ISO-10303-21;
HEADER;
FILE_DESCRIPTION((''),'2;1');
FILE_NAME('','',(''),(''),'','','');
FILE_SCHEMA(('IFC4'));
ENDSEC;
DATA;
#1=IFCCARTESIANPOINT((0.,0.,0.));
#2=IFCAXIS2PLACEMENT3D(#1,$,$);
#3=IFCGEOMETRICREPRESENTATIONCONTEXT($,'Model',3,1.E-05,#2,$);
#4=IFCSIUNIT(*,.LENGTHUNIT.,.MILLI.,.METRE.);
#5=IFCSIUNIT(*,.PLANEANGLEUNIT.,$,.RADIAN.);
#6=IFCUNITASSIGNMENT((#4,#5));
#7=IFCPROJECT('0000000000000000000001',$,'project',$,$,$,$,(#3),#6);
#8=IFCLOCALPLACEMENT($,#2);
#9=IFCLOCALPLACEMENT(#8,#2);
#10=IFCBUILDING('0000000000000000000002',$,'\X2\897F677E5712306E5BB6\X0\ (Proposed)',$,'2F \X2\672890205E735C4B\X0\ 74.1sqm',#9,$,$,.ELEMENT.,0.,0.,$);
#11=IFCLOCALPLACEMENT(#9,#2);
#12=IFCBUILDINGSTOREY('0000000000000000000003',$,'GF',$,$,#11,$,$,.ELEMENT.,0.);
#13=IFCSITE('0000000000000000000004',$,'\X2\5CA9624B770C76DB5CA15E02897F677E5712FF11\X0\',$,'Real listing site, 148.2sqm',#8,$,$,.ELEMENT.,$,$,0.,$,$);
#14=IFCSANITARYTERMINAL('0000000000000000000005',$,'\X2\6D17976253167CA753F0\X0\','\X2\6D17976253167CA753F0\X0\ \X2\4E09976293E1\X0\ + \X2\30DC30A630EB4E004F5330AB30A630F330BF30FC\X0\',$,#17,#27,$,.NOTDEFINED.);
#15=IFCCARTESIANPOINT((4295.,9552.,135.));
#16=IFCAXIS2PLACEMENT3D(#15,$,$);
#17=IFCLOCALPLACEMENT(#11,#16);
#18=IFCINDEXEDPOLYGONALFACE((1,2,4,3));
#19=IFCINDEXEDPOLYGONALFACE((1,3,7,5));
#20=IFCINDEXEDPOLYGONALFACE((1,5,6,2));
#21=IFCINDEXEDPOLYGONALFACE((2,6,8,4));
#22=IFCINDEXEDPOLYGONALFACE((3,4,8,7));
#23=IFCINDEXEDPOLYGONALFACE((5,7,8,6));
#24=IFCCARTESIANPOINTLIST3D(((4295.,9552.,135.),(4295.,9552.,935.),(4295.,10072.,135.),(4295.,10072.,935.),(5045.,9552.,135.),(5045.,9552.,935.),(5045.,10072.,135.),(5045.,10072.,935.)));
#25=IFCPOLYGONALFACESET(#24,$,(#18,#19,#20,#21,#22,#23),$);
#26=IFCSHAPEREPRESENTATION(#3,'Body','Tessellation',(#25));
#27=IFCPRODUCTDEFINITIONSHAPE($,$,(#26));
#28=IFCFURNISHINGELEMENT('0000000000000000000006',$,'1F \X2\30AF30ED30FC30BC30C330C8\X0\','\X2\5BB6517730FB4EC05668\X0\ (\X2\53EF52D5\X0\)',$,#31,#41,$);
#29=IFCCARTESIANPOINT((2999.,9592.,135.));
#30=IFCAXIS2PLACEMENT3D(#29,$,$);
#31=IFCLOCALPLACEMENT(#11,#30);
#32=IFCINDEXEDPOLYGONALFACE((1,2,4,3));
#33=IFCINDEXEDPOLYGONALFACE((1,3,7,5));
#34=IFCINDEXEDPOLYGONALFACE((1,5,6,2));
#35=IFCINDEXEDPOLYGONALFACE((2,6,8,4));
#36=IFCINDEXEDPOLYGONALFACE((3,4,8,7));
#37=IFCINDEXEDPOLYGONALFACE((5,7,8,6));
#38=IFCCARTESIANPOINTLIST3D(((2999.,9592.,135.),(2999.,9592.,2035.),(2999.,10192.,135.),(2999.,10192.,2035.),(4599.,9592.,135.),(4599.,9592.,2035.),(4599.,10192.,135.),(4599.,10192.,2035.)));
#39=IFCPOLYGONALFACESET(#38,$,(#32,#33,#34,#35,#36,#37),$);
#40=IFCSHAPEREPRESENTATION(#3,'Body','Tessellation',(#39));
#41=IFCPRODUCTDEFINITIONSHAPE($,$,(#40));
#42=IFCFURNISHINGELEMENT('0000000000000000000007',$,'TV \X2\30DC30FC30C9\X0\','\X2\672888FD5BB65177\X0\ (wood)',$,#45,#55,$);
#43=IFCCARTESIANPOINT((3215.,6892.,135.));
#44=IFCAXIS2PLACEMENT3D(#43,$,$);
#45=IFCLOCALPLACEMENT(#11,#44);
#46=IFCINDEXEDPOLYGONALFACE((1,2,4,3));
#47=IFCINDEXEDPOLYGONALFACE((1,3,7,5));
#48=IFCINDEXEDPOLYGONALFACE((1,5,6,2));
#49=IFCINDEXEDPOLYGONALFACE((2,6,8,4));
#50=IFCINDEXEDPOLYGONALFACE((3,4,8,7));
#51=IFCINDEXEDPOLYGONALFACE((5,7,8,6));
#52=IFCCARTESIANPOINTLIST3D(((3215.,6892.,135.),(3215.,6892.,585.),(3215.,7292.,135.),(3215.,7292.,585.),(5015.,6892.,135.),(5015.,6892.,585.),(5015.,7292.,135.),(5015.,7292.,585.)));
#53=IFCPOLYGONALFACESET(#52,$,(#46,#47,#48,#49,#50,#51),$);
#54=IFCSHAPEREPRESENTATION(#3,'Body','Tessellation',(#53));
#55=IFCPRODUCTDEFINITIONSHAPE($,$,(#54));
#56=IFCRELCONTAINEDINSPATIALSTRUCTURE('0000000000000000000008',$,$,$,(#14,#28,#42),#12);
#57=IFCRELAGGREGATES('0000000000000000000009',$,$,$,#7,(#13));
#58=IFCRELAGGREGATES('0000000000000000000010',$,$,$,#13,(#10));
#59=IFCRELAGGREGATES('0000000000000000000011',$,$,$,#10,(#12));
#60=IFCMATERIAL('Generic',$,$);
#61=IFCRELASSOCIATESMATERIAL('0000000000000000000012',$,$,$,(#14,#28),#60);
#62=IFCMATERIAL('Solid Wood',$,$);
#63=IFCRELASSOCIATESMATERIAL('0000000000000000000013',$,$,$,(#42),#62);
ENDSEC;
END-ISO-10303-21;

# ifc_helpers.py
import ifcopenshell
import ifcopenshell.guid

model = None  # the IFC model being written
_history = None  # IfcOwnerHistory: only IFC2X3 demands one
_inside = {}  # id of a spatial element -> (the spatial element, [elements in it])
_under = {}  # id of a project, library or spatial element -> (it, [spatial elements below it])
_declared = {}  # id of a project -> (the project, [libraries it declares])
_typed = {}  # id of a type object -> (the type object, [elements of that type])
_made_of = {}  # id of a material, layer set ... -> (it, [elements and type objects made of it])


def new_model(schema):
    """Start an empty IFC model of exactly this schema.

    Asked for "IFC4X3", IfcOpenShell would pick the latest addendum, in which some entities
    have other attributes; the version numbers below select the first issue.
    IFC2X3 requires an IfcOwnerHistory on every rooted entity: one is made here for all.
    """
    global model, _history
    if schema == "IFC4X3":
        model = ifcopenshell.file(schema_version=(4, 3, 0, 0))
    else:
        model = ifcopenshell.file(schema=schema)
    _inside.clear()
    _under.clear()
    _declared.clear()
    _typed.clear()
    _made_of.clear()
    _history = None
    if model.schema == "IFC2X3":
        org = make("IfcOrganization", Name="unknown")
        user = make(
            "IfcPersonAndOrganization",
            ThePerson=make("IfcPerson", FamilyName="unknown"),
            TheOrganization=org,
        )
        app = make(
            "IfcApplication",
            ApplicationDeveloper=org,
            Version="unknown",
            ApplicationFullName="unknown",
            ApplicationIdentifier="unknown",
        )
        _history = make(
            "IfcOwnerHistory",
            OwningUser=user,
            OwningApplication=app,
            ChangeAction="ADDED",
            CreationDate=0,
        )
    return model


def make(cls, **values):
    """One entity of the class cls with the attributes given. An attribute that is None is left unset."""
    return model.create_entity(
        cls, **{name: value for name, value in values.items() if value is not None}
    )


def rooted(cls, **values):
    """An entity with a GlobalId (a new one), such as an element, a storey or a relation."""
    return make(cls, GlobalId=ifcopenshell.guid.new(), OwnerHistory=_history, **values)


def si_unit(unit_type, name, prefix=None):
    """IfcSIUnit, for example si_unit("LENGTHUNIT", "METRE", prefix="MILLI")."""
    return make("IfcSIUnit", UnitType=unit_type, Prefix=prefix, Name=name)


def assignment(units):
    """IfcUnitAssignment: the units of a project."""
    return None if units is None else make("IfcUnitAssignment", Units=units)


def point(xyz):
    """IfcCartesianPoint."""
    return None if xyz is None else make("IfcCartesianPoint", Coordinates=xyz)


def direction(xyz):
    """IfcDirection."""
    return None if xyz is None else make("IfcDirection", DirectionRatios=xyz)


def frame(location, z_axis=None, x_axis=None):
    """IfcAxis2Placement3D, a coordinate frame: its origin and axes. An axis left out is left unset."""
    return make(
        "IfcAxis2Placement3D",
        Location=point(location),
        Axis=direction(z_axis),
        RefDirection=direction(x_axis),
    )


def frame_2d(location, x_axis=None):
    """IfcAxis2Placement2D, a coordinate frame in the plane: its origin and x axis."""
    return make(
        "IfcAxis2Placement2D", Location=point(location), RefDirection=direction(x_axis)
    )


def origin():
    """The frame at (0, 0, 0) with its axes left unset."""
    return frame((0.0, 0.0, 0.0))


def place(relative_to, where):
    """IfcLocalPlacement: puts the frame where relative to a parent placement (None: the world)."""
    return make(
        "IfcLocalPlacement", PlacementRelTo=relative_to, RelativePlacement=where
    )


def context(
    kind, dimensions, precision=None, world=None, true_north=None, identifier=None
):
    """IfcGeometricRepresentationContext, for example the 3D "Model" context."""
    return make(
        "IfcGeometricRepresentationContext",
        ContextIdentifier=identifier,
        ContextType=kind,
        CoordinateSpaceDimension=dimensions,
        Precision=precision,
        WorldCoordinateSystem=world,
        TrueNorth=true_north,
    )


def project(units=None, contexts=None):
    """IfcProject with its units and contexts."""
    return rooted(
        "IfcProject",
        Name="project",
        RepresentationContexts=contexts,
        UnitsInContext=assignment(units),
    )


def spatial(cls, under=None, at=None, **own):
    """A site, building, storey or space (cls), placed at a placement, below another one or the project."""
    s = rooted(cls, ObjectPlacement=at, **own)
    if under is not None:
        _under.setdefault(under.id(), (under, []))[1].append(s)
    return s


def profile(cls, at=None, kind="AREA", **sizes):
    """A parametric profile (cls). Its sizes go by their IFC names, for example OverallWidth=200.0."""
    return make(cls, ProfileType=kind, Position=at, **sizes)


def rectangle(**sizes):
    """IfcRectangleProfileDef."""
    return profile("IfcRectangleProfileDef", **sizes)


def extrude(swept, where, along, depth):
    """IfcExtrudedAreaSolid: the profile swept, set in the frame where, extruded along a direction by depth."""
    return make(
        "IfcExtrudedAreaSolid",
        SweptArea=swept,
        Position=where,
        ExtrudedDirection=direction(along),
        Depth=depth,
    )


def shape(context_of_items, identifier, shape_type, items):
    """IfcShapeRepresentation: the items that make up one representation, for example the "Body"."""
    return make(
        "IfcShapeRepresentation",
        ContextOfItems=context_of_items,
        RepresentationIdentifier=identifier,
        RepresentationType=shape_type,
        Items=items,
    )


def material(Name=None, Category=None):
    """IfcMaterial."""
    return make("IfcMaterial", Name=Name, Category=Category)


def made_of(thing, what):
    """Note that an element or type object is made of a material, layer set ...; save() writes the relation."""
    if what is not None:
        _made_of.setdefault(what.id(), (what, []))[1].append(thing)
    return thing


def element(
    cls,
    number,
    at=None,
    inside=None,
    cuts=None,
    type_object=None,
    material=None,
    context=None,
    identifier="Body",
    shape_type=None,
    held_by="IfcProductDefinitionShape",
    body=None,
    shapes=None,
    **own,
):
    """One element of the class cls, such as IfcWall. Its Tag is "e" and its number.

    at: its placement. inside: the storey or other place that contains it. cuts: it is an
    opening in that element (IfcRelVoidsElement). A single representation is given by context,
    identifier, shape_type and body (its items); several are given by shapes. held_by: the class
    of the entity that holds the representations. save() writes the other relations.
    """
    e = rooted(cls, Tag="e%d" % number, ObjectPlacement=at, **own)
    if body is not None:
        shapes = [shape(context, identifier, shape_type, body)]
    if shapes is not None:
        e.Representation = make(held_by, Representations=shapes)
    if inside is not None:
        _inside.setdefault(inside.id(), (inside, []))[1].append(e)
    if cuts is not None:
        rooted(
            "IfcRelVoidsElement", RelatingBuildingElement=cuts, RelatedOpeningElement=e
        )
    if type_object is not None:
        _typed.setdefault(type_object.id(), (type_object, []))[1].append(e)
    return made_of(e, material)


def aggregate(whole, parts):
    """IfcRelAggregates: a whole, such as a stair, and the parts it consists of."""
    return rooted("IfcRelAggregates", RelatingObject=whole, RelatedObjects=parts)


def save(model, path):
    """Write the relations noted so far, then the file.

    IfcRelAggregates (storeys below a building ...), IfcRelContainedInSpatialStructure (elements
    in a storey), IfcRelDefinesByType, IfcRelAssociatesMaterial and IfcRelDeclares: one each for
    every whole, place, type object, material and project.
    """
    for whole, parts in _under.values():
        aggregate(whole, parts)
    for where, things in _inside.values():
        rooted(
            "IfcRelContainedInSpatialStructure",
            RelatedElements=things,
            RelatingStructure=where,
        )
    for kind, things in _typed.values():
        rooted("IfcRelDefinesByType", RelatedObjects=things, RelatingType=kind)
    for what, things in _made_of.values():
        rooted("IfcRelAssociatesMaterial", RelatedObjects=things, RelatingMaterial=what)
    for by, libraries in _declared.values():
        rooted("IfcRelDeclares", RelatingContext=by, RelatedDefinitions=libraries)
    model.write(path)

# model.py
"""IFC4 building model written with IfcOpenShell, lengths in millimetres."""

from ifc_helpers import new_model, si_unit, frame, frame_2d, origin, place, context, project, spatial, rectangle, extrude, material, element, save


model = new_model("IFC4")

# Units and contexts
model_context = context("Model", 3, precision=1e-05, world=origin())
ifc_project = project(units=[si_unit("LENGTHUNIT", "METRE", prefix="MILLI"), si_unit("PLANEANGLEUNIT", "RADIAN")], contexts=[model_context])

# Site, building, storey
site_placement = place(None, origin())
site = spatial("IfcSite", under=ifc_project, at=site_placement, Name="岩手県盛岡市西松園１", ObjectType="Real listing site, 148.2sqm", CompositionType="ELEMENT", RefElevation=0.0)
building_placement = place(site_placement, origin())
building = spatial("IfcBuilding", under=site, at=building_placement, Name="西松園の家 (Proposed)", ObjectType="2F 木造平屋 74.1sqm", CompositionType="ELEMENT", ElevationOfRefHeight=0.0, ElevationOfTerrain=0.0)
storey_placement = place(building_placement, origin())
storey = spatial("IfcBuildingStorey", under=building, at=storey_placement, Name="GF", CompositionType="ELEMENT", Elevation=0.0)

# Shared definitions
ifc_material_1 = material(Name="Solid Wood")

# Shared definitions
ifc_material_2 = material(Name="Generic")

# Sanitary terminal
sanitary_terminal_1_placement = place(storey_placement, frame((4295.0, 9552.0, 135.0)))
element("IfcSanitaryTerminal", 1, at=sanitary_terminal_1_placement, inside=storey, material=ifc_material_2, Name="洗面化粧台", Description="洗面化粧台 三面鏡 + ボウル一体カウンター", PredefinedType="NOTDEFINED", context=model_context, shape_type="SweptSolid", body=[
    extrude(rectangle(XDim=750.0, YDim=520.0, at=frame_2d((375.0, 260.0))), frame((4295.0, 9552.0, 135.0)), (0.0, 0.0, 1.0), 800.0),
])

# Furnishing elements
furnishing_1_placement = place(storey_placement, frame((2999.0, 9592.0, 135.0)))
element("IfcFurnishingElement", 2, at=furnishing_1_placement, inside=storey, material=ifc_material_2, Name="1F クローゼット", Description="家具・什器 (可動)", context=model_context, shape_type="SweptSolid", body=[
    extrude(rectangle(XDim=1600.0, YDim=600.0, at=frame_2d((800.0, 300.0))), frame((2999.0, 9592.0, 135.0)), (0.0, 0.0, 1.0), 1900.0),
])
furnishing_2_placement = place(storey_placement, frame((3215.0, 6892.0, 135.0)))
element("IfcFurnishingElement", 3, at=furnishing_2_placement, inside=storey, material=ifc_material_1, Name="TV ボード", Description="木製家具 (wood)", context=model_context, shape_type="SweptSolid", body=[
    extrude(rectangle(XDim=1800.0, YDim=400.0, at=frame_2d((900.0, 200.0))), frame((3215.0, 6892.0, 135.0)), (0.0, 0.0, 1.0), 450.0),
])

save(model, "model.ifc")
